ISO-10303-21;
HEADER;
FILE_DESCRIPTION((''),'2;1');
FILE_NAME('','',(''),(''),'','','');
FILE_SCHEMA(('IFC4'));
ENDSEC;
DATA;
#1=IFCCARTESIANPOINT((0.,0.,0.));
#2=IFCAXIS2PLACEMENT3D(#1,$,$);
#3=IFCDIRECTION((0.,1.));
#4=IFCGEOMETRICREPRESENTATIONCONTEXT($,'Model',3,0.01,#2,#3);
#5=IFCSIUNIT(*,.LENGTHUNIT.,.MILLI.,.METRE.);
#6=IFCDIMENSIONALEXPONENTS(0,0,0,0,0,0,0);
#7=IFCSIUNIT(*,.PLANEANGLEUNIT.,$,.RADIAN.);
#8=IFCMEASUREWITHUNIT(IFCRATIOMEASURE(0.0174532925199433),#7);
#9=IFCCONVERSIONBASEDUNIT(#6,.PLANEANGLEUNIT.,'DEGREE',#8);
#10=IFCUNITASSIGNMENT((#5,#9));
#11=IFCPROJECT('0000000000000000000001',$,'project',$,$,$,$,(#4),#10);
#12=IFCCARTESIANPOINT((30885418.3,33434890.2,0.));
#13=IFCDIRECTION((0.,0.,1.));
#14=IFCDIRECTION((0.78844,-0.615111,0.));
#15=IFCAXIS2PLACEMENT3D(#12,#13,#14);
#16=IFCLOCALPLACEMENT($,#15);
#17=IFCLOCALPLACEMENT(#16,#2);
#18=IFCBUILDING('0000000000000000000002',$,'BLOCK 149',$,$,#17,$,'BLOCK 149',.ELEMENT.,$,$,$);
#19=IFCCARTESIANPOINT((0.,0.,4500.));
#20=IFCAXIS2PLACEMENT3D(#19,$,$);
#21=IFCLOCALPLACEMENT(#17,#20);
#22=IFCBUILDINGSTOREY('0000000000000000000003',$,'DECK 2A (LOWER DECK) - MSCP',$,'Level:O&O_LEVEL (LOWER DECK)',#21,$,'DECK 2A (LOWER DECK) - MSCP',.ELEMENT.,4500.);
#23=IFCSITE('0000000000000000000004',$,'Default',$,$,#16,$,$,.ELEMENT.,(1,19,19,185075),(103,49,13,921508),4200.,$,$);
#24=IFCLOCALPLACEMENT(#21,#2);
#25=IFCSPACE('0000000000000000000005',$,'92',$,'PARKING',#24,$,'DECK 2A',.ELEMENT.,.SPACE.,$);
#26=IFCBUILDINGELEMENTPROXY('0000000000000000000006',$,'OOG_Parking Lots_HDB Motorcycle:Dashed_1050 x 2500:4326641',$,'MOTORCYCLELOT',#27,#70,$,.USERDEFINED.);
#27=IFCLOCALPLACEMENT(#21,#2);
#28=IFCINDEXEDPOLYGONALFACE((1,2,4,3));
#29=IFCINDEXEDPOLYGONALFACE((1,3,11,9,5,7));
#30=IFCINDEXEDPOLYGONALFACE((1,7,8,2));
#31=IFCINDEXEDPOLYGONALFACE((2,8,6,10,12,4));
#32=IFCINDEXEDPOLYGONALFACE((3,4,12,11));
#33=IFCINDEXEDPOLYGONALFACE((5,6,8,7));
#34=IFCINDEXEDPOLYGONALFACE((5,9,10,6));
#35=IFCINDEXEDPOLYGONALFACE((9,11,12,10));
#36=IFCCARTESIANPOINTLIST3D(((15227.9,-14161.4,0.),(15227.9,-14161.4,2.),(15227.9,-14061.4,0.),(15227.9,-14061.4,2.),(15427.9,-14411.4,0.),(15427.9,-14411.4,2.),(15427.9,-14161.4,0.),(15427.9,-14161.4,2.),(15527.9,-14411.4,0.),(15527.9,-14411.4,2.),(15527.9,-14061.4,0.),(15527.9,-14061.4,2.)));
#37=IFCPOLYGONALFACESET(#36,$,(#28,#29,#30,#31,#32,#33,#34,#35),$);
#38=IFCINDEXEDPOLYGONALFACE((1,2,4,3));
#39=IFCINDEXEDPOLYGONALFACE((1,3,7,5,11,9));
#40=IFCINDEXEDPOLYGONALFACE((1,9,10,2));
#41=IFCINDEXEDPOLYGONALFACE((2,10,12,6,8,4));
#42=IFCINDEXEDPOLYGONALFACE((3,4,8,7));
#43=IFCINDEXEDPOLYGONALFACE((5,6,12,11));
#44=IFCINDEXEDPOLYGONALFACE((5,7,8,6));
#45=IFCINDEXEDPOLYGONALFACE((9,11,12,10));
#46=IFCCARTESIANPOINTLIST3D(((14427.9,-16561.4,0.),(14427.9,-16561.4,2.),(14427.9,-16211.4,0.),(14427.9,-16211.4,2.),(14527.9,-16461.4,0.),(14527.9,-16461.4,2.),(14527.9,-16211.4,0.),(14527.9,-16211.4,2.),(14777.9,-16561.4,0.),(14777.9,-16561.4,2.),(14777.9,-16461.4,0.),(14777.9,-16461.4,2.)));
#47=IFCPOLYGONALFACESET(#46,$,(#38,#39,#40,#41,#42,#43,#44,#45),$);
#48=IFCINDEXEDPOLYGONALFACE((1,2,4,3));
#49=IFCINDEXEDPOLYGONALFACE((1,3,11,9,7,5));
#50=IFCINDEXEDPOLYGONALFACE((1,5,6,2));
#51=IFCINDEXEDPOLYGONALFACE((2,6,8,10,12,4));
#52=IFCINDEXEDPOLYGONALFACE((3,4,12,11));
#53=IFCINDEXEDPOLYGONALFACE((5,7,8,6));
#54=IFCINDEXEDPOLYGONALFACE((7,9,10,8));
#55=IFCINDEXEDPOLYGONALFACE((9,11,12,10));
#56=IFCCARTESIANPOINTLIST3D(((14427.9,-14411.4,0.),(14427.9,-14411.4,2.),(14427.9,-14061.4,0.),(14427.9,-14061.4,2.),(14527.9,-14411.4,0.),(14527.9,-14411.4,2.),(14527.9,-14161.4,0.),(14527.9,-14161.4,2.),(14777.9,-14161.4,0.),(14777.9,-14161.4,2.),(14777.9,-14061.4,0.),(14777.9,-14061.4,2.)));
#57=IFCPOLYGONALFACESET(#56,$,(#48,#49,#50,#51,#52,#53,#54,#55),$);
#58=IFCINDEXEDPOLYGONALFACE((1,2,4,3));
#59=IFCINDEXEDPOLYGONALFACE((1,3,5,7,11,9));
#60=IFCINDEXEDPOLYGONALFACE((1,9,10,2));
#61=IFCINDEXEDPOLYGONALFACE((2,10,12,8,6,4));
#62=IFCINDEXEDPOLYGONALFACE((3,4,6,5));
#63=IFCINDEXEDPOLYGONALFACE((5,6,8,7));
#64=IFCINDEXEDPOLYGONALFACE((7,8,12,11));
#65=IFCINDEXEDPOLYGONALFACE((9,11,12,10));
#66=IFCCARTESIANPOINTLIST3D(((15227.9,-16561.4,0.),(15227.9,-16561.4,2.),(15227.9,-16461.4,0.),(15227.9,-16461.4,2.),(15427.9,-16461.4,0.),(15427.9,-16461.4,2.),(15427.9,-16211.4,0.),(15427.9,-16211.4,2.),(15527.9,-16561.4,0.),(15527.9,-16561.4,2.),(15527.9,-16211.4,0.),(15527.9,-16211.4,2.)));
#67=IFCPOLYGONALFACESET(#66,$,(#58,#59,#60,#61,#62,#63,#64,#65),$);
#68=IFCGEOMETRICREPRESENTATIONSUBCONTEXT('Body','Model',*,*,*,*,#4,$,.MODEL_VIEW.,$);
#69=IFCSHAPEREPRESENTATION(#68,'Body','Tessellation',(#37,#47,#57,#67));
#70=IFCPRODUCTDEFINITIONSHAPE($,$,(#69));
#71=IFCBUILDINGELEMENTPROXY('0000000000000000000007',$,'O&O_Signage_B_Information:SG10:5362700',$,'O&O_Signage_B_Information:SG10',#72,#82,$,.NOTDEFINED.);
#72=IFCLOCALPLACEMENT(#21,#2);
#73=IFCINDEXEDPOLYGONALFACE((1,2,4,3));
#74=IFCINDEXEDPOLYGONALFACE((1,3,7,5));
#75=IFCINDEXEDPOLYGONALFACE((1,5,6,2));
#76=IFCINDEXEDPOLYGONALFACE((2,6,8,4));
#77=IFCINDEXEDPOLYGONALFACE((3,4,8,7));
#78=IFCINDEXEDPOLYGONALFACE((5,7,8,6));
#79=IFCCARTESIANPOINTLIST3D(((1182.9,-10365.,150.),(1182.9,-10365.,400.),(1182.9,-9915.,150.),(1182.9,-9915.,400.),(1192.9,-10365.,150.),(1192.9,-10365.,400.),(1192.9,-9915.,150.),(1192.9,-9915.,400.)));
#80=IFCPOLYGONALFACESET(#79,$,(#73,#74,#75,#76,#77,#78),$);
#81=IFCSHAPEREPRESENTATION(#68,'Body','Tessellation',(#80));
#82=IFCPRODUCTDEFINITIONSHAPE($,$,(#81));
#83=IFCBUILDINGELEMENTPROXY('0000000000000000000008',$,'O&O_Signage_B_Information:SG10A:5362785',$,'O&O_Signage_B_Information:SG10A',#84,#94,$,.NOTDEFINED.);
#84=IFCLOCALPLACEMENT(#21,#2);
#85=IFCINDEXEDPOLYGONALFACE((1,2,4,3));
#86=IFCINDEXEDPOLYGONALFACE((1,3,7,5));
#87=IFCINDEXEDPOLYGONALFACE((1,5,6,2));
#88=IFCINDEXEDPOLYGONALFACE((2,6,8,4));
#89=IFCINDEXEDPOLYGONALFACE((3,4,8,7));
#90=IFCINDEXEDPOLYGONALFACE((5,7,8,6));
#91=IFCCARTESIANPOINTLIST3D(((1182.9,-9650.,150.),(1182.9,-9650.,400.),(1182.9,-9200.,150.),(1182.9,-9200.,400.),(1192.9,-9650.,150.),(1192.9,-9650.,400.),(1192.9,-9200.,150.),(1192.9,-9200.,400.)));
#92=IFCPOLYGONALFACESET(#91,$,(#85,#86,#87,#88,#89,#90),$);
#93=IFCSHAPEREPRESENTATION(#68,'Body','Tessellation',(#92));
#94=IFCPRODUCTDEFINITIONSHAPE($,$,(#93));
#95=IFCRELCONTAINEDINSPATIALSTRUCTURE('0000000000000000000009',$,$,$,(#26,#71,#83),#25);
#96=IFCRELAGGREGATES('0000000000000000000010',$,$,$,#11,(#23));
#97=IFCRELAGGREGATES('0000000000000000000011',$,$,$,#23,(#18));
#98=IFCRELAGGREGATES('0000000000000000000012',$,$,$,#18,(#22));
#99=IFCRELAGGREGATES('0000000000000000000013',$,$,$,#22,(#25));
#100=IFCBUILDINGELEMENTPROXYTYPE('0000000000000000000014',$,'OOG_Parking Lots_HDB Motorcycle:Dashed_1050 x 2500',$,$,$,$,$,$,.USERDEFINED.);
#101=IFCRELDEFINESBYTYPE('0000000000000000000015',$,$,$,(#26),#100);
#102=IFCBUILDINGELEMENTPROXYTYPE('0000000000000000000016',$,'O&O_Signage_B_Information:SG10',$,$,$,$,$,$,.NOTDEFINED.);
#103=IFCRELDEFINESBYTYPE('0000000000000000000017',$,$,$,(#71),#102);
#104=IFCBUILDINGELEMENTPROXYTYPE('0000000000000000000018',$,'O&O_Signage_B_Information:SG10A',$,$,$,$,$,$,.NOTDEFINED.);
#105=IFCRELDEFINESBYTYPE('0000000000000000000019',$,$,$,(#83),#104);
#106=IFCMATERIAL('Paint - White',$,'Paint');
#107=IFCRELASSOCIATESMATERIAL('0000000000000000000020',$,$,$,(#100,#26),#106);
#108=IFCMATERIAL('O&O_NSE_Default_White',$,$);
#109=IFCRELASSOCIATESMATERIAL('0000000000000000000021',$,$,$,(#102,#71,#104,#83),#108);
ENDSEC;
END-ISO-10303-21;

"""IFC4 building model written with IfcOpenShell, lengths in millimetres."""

from ifc_helpers import new_model, entity, si_unit, converted_unit, direction, frame, origin, place, context, subcontext, project, spatial, indexed_curve, outline, extrude, source, transform, mapped, material, type_object, type_shapes, element, save


model = new_model("IFC4")

# Units and contexts
model_context = context("Model", 3, precision=0.01, world=origin(), true_north=direction((0.0, 1.0)))
body_context = subcontext(model_context, "Body", "Model", "MODEL_VIEW")
ifc_project = project(units=[si_unit("LENGTHUNIT", "METRE", prefix="MILLI"), converted_unit("PLANEANGLEUNIT", "DEGREE", entity("IfcRatioMeasure", 0.0174532925199433), si_unit("PLANEANGLEUNIT", "RADIAN"), dimensions=[0, 0, 0, 0, 0, 0, 0])], contexts=[model_context])

# Site, building, storey
site_placement = place(None, frame((30885418.3, 33434890.2, 0.0), z_axis=(0.0, 0.0, 1.0), x_axis=(0.78844, -0.615111, 0.0)))
site = spatial("IfcSite", under=ifc_project, at=site_placement, Name="Default", CompositionType="ELEMENT", RefLatitude=(1, 19, 19, 185075), RefLongitude=(103, 49, 13, 921508), RefElevation=4200.0)
building_placement = place(site_placement, origin())
building = spatial("IfcBuilding", under=site, at=building_placement, Name="BLOCK 149", LongName="BLOCK 149", CompositionType="ELEMENT")
storey_placement = place(building_placement, frame((0.0, 0.0, 4500.0)))
storey = spatial("IfcBuildingStorey", under=building, at=storey_placement, Name="DECK 2A (LOWER DECK) - MSCP", ObjectType="Level:O&O_LEVEL (LOWER DECK)", LongName="DECK 2A (LOWER DECK) - MSCP", CompositionType="ELEMENT", Elevation=4500.0)

# Shared definitions
space_placement = place(storey_placement, origin())
space = spatial("IfcSpace", under=storey, at=space_placement, Name="92", ObjectType="PARKING", LongName="DECK 2A", CompositionType="ELEMENT", PredefinedType="SPACE")

# Building element proxies
ifc_material_1 = material(Name="Paint - White", Category="Paint")
building_element_proxy_type_1 = type_object("IfcBuildingElementProxyType", Name="OOG_Parking Lots_HDB Motorcycle:Dashed_1050 x 2500", PredefinedType="USERDEFINED", material=ifc_material_1)
shared_shape_1 = source(origin(), body_context, "Body", "SweptSolid", [
    extrude(outline(indexed_curve([(-200.0, -133.3), (150.0, -133.3), (150.0, 166.7), (50.0, 166.7), (50.0, -33.3), (-200.0, -33.3), (-200.0, -133.3)], self_intersect=False)), frame((916.7, -100.0, 0.0), z_axis=(0.0, 0.0, 1.0), x_axis=(0.0, 1.0, 0.0)), (0.0, 0.0, 1.0), 2.0),
    extrude(outline(indexed_curve([(-200.0, -150.0), (150.0, -150.0), (150.0, 200.0), (50.0, 200.0), (50.0, -50.0), (-200.0, -50.0), (-200.0, -150.0)], self_intersect=False)), frame((100.0, -2300.0, 0.0), z_axis=(0.0, 0.0, 1.0), x_axis=(0.0, -1.0, 0.0)), (0.0, 0.0, 1.0), 2.0),
    extrude(outline(indexed_curve([(-200.0, -150.0), (150.0, -150.0), (150.0, 200.0), (50.0, 200.0), (50.0, -50.0), (-200.0, -50.0), (-200.0, -150.0)], self_intersect=False)), frame((100.0, -100.0, 0.0), z_axis=(0.0, 0.0, 1.0), x_axis=(-1.0, 0.0, 0.0)), (0.0, 0.0, 1.0), 2.0),
    extrude(outline(indexed_curve([(-166.7, -150.0), (133.3, -150.0), (133.3, 200.0), (33.3, 200.0), (33.3, -50.0), (-166.7, -50.0), (-166.7, -150.0)], self_intersect=False)), frame((916.7, -2300.0, 0.0)), (0.0, 0.0, 1.0), 2.0),
])
type_shapes(building_element_proxy_type_1, [shared_shape_1])
for number, where, name in (
    (1, (14477.9, -14111.4, 0.0), "OOG_Parking Lots_HDB Motorcycle:Dashed_1050 x 2500:4326641"),
):
    element("IfcBuildingElementProxy", number, at=place(space_placement, frame(where)), inside=space, type_object=building_element_proxy_type_1, material=ifc_material_1, Name=name, ObjectType="MOTORCYCLELOT", PredefinedType="USERDEFINED", context=body_context, shape_type="MappedRepresentation", body=[
        mapped(shared_shape_1, transform((0.0, 0.0, 0.0), scale=1.0)),
    ])
ifc_material_2 = material(Name="O&O_NSE_Default_White")
building_element_proxy_type_2 = type_object("IfcBuildingElementProxyType", Name="O&O_Signage_B_Information:SG10", PredefinedType="NOTDEFINED", material=ifc_material_2)
shared_shape_2 = source(origin(), body_context, "Body", "SweptSolid", [
    extrude(outline(indexed_curve([(-5.0, -225.0), (5.0, -225.0), (5.0, 225.0), (-5.0, 225.0), (-5.0, -225.0)], self_intersect=False)), frame((0.0, 5.0, 150.0), z_axis=(0.0, 0.0, 1.0), x_axis=(0.0, 1.0, 0.0)), (0.0, 0.0, 1.0), 250.0),
])
type_shapes(building_element_proxy_type_2, [shared_shape_2])
for number, where, z_axis, x_axis, name in (
    (2, (1182.9, -10140.0, 0.0), (0.0, 0.0, 1.0), (0.0, -1.0, 0.0), "O&O_Signage_B_Information:SG10:5362700"),
):
    element("IfcBuildingElementProxy", number, at=place(space_placement, frame(where, z_axis=z_axis, x_axis=x_axis)), inside=space, type_object=building_element_proxy_type_2, material=ifc_material_2, Name=name, ObjectType="O&O_Signage_B_Information:SG10", PredefinedType="NOTDEFINED", context=body_context, shape_type="MappedRepresentation", body=[
        mapped(shared_shape_2, transform((0.0, 0.0, 0.0), scale=1.0)),
    ])
building_element_proxy_type_3 = type_object("IfcBuildingElementProxyType", Name="O&O_Signage_B_Information:SG10A", PredefinedType="NOTDEFINED", material=ifc_material_2)
shared_shape_3 = source(origin(), body_context, "Body", "SweptSolid", [
    extrude(outline(indexed_curve([(-5.0, -225.0), (5.0, -225.0), (5.0, 225.0), (-5.0, 225.0), (-5.0, -225.0)], self_intersect=False)), frame((0.0, 5.0, 150.0), z_axis=(0.0, 0.0, 1.0), x_axis=(0.0, 1.0, 0.0)), (0.0, 0.0, 1.0), 250.0),
])
type_shapes(building_element_proxy_type_3, [shared_shape_3])
for number, where, z_axis, x_axis, name in (
    (3, (1182.9, -9425.0, 0.0), (0.0, 0.0, 1.0), (0.0, -1.0, 0.0), "O&O_Signage_B_Information:SG10A:5362785"),
):
    element("IfcBuildingElementProxy", number, at=place(space_placement, frame(where, z_axis=z_axis, x_axis=x_axis)), inside=space, type_object=building_element_proxy_type_3, material=ifc_material_2, Name=name, ObjectType="O&O_Signage_B_Information:SG10A", PredefinedType="NOTDEFINED", context=body_context, shape_type="MappedRepresentation", body=[
        mapped(shared_shape_3, transform((0.0, 0.0, 0.0), scale=1.0)),
    ])

save(model, "model.ifc")
